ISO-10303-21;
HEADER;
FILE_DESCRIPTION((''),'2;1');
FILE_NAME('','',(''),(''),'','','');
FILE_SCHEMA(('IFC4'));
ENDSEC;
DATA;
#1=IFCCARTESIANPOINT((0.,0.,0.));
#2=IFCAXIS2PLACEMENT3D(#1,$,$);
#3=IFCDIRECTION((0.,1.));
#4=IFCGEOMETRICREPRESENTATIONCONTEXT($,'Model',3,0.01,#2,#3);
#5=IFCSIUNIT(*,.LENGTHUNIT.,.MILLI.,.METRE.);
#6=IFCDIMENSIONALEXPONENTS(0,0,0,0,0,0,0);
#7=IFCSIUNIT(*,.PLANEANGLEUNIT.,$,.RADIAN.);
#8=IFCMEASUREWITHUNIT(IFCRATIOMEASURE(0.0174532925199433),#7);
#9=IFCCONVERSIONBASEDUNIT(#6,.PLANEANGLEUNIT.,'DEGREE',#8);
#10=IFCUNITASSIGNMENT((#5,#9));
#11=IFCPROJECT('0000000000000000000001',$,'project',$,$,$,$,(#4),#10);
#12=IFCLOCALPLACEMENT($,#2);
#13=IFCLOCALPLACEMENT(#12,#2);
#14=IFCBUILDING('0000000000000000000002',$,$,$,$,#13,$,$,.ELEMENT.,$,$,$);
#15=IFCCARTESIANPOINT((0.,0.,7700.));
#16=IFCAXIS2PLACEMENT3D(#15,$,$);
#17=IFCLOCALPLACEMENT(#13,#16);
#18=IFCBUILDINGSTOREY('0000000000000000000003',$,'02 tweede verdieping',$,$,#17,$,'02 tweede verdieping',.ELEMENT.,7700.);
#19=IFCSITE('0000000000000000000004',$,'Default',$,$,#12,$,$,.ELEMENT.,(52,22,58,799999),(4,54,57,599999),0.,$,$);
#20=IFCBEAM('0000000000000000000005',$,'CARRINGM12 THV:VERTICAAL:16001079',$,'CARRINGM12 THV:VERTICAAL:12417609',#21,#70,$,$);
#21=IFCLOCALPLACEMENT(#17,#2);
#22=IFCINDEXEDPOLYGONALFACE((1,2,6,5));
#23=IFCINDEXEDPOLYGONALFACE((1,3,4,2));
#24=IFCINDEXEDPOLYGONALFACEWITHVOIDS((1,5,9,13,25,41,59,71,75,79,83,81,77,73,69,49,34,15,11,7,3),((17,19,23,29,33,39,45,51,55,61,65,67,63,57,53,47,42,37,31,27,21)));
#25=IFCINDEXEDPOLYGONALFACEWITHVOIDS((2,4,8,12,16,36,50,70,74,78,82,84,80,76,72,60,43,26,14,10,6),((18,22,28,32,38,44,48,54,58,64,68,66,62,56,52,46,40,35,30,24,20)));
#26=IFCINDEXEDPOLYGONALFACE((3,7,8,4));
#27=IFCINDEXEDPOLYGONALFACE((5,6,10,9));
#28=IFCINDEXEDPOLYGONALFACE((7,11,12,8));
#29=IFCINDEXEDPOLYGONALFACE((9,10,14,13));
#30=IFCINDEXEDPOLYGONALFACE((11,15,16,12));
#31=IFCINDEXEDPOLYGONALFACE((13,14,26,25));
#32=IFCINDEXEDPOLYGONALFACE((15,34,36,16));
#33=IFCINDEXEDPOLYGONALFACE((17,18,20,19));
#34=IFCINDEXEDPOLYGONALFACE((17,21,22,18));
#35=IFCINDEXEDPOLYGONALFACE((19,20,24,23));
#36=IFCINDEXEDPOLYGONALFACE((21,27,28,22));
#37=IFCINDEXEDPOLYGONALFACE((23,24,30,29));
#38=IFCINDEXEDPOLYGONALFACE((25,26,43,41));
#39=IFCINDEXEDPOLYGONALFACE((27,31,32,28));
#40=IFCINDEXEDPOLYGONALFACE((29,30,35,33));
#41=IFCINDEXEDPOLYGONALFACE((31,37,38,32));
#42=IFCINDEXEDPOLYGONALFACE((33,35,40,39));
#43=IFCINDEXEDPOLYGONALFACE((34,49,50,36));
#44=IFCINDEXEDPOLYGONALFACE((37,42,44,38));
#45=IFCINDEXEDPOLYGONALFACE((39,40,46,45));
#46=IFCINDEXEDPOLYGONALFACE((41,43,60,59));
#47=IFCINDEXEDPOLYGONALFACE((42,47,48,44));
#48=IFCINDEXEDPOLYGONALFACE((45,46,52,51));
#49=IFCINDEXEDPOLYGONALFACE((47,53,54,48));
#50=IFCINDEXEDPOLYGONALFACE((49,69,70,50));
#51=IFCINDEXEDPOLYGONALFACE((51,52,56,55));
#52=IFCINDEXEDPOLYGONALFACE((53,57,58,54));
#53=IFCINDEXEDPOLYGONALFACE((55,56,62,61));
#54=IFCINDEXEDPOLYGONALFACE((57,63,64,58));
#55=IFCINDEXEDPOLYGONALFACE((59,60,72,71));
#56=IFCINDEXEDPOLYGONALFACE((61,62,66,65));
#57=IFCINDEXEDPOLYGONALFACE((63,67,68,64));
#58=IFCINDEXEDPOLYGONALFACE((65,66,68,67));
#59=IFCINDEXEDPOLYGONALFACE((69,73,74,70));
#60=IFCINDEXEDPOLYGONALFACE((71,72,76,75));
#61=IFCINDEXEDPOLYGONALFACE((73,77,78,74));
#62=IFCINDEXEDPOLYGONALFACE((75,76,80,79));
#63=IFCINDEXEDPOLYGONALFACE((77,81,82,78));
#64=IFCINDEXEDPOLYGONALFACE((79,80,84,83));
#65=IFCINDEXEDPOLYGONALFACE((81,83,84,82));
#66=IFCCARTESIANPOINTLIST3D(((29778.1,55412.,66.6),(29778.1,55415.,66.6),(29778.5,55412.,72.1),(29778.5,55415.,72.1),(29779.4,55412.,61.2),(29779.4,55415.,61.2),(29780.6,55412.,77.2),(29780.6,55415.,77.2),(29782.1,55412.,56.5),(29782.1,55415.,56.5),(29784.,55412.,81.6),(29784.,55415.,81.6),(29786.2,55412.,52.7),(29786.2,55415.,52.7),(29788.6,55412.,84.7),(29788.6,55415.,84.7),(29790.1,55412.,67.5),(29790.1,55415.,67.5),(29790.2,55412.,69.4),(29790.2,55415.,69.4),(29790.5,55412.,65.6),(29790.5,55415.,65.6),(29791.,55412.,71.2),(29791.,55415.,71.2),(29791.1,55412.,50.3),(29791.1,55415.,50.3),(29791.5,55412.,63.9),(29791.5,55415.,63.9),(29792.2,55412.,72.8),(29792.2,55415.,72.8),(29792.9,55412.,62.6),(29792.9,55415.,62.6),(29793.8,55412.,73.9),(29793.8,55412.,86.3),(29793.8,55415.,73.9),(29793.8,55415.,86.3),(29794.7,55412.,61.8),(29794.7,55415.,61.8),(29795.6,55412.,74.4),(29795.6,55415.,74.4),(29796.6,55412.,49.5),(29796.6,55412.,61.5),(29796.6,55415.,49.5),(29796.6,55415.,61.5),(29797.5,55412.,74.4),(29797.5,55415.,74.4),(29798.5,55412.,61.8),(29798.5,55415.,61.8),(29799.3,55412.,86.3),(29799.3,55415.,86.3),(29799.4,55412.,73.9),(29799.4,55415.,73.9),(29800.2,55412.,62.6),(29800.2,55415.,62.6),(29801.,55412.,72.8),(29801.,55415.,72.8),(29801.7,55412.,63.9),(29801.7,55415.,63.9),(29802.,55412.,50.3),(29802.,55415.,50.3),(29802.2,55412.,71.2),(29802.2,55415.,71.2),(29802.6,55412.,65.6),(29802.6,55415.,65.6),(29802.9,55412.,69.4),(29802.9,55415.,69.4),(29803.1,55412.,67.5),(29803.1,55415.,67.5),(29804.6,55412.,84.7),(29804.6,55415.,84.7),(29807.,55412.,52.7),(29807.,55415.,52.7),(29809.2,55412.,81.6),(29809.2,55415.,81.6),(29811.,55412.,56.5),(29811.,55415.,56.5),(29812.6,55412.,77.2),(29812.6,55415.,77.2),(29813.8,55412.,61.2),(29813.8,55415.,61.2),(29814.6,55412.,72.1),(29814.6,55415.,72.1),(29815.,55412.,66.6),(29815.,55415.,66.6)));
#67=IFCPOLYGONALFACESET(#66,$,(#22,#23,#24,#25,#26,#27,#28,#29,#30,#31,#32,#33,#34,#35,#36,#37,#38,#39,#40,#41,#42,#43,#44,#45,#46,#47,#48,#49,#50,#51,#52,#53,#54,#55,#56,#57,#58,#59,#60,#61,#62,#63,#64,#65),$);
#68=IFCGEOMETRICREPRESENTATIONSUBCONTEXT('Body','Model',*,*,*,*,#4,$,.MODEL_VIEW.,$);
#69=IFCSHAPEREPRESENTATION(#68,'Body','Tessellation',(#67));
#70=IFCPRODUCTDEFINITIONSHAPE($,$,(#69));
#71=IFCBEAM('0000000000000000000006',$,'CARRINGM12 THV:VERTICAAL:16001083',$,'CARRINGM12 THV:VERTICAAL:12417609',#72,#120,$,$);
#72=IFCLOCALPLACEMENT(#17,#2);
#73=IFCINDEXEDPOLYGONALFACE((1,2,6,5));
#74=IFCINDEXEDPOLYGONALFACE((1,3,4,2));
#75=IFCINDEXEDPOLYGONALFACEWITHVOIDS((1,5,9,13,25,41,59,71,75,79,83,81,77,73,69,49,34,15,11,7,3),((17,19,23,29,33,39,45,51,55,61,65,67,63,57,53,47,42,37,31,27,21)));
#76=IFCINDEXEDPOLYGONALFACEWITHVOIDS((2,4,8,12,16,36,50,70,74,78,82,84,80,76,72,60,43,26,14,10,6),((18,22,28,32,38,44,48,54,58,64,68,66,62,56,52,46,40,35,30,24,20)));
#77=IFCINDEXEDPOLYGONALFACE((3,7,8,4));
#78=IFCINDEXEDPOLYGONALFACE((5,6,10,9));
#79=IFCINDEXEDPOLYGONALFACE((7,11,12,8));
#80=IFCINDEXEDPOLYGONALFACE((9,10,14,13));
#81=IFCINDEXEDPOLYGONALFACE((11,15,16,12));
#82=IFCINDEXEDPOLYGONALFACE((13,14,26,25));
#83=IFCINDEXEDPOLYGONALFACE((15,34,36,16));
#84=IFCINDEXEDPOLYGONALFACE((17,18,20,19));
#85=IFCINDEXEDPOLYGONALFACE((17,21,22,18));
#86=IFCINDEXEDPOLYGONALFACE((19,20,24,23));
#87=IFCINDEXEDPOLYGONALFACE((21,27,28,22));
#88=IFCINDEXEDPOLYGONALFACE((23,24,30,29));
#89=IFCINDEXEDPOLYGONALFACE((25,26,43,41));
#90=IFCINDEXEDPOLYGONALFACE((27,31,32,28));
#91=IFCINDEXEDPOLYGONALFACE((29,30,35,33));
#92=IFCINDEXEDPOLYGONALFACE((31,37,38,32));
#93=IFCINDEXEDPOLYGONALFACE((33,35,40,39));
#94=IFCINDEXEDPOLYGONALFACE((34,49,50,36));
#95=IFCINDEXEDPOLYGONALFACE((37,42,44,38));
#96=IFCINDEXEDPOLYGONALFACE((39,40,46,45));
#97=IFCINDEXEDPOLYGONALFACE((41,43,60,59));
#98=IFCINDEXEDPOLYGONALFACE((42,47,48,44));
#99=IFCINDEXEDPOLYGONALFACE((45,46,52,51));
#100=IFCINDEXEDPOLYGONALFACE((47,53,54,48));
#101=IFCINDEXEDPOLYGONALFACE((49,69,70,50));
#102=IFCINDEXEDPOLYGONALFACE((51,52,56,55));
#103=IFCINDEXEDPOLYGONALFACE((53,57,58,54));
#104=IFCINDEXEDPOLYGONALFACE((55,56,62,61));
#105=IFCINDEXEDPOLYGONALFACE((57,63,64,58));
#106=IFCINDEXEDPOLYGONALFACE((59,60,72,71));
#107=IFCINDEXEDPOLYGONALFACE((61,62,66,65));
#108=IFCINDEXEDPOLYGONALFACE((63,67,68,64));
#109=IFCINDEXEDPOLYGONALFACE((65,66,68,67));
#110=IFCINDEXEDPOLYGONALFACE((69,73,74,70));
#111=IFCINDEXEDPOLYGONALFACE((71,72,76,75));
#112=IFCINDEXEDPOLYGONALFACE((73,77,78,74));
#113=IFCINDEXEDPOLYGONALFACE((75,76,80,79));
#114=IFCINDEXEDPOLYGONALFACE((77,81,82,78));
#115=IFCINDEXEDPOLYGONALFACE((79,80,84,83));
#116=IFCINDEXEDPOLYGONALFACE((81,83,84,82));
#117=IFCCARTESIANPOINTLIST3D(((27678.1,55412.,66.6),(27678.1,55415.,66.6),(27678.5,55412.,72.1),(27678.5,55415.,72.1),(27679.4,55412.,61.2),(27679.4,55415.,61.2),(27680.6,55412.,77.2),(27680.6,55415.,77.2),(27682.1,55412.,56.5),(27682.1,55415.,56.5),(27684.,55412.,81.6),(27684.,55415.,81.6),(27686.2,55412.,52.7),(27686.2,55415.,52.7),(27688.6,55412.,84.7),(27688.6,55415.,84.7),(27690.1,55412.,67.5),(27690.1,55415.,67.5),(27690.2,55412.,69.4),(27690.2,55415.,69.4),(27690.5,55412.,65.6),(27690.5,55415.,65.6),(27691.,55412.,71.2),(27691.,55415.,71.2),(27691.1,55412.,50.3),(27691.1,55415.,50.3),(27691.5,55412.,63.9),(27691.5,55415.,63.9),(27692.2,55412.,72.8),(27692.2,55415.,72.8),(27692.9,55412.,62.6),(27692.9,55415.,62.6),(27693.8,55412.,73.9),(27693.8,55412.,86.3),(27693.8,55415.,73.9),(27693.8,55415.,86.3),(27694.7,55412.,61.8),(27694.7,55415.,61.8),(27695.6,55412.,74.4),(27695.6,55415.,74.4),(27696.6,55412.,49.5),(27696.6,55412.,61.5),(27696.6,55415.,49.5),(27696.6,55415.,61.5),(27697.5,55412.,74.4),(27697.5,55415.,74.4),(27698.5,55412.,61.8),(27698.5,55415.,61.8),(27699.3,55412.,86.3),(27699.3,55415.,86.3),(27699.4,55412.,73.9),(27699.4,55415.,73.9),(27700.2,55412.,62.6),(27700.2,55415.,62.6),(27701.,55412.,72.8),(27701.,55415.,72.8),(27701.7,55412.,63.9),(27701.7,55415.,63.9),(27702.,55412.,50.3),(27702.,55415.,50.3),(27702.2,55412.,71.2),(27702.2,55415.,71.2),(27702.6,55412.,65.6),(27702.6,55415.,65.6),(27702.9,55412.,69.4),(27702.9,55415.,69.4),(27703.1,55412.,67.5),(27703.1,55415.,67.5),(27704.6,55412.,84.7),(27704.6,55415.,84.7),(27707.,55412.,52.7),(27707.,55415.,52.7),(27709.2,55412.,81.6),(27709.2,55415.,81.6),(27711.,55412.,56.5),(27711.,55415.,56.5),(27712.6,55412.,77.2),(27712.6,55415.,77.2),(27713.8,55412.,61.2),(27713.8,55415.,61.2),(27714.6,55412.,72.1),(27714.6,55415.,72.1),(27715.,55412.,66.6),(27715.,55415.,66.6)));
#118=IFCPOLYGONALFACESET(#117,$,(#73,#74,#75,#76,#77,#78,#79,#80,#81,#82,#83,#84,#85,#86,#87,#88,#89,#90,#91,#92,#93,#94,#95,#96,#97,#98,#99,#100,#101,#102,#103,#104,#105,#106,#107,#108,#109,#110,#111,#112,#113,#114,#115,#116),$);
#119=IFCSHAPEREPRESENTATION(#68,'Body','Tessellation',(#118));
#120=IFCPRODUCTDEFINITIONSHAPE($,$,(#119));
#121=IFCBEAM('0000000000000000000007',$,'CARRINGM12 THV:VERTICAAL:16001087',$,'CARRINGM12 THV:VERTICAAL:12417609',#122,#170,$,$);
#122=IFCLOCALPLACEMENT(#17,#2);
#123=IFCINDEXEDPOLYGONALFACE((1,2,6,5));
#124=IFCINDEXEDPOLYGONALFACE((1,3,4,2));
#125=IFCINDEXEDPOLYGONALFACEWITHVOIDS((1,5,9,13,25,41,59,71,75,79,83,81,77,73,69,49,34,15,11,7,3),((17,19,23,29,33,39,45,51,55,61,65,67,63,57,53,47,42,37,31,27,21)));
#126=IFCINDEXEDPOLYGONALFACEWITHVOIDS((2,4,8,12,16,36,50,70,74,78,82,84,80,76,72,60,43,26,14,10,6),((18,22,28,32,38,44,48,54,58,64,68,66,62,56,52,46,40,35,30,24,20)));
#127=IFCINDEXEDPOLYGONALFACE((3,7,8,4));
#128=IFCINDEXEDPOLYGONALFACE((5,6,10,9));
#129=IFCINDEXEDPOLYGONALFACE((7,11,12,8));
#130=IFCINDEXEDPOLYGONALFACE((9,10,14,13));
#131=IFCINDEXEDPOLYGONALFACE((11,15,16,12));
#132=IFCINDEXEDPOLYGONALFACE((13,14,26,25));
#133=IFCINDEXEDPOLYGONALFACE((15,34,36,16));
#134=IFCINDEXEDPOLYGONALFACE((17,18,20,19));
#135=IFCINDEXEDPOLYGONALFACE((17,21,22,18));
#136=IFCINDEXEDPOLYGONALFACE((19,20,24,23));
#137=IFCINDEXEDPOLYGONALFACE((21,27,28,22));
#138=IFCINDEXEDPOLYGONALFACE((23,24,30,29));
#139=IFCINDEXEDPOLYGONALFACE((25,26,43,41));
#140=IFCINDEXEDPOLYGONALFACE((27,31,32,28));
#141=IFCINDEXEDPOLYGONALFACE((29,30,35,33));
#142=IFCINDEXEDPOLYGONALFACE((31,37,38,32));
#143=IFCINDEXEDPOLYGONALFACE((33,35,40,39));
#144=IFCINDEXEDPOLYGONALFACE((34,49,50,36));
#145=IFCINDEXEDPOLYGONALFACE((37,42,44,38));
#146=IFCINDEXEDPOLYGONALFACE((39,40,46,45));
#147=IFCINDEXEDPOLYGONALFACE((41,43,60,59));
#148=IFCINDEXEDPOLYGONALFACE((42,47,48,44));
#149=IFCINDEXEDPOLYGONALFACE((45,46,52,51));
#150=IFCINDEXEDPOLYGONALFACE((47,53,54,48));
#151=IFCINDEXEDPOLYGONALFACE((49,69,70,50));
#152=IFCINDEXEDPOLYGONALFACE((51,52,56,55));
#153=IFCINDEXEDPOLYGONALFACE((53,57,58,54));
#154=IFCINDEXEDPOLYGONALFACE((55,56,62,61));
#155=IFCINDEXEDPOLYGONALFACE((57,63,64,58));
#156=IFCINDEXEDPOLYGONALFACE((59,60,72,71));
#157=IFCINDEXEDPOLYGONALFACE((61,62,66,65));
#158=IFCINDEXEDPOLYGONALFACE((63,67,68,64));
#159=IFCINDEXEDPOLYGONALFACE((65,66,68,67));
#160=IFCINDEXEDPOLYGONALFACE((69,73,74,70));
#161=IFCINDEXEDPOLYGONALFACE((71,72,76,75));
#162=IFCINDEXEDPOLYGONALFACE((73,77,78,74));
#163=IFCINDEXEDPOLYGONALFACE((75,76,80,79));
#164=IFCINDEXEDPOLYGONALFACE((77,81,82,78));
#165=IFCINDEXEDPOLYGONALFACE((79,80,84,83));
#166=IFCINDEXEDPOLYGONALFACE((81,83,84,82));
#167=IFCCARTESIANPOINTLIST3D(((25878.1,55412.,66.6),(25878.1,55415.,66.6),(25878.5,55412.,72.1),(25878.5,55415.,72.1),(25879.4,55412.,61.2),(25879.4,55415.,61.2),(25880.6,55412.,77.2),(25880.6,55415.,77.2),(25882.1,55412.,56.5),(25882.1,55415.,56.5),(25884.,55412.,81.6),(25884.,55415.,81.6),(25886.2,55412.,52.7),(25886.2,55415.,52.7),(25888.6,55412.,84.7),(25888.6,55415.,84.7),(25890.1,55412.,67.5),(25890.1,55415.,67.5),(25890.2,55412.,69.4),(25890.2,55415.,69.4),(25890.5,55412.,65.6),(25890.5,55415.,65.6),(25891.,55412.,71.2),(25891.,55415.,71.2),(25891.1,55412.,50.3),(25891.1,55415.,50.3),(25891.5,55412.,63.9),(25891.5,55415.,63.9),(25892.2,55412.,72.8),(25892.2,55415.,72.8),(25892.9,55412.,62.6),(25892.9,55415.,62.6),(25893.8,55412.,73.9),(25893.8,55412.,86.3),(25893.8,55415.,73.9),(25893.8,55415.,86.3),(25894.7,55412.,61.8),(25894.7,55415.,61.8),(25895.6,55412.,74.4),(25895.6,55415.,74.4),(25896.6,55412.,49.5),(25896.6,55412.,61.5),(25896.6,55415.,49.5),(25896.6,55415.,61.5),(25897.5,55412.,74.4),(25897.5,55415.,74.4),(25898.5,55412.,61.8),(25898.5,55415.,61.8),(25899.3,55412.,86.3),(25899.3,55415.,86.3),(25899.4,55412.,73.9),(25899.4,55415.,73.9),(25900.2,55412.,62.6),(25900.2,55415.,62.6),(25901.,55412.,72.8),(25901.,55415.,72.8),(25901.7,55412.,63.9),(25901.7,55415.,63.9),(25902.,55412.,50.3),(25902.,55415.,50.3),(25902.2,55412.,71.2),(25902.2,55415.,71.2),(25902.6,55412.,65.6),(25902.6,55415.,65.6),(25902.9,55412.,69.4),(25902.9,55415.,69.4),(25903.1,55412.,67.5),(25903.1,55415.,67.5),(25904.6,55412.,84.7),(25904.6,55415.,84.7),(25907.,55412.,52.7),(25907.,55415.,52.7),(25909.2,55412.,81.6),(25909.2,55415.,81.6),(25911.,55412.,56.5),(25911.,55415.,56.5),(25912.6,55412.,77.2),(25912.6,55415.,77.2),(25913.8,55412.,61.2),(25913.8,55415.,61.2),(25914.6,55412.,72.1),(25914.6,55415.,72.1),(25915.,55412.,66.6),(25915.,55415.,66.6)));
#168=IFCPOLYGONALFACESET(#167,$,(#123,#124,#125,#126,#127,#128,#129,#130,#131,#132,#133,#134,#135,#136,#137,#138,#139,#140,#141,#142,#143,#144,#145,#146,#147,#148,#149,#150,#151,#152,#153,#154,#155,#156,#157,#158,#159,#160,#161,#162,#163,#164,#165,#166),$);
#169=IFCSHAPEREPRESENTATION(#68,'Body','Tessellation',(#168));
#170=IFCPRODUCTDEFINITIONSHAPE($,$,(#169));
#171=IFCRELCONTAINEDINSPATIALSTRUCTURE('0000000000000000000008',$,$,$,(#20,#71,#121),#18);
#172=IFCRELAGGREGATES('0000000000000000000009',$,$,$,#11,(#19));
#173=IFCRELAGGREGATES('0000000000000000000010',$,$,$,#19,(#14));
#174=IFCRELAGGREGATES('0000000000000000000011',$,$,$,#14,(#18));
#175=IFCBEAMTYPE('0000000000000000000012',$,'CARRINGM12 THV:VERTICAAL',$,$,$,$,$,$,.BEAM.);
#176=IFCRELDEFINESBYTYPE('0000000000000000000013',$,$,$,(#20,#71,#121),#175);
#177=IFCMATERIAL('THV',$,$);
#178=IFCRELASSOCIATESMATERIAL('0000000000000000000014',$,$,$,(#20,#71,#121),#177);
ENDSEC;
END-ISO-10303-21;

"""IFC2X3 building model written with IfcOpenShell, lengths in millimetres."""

from ifc_helpers import new_model, entity, si_unit, converted_unit, direction, frame, origin, origin_2d_with_axis, place, context, subcontext, project, spatial, hollow_circle, extrude, material, type_object, element, save


model = new_model("IFC2X3")

# Units and contexts
model_context = context("Model", 3, precision=0.01, world=origin(), true_north=direction((0.0, 1.0)))
body_context = subcontext(model_context, "Body", "Model", "MODEL_VIEW")
ifc_project = project(units=[si_unit("LENGTHUNIT", "METRE", prefix="MILLI"), converted_unit("PLANEANGLEUNIT", "DEGREE", entity("IfcRatioMeasure", 0.0174532925199433), si_unit("PLANEANGLEUNIT", "RADIAN"), dimensions=[0, 0, 0, 0, 0, 0, 0])], contexts=[model_context])

# Site, building, storey
site_placement = place(None, origin())
site = spatial("IfcSite", under=ifc_project, at=site_placement, Name="Default", CompositionType="ELEMENT", RefLatitude=(52, 22, 58, 799999), RefLongitude=(4, 54, 57, 599999), RefElevation=0.0)
building_placement = place(site_placement, origin())
building = spatial("IfcBuilding", under=site, at=building_placement, CompositionType="ELEMENT")
storey_placement = place(building_placement, frame((0.0, 0.0, 7700.0)))
storey = spatial("IfcBuildingStorey", under=building, at=storey_placement, Name="02 tweede verdieping", LongName="02 tweede verdieping", CompositionType="ELEMENT", Elevation=7700.0)

# Beams
ifc_material_1 = material(Name="THV")
beam_type_1 = type_object("IfcBeamType", Name="CARRINGM12 THV:VERTICAAL", PredefinedType="BEAM")
beam_1_placement = place(storey_placement, origin())
element("IfcBeam", 1, at=beam_1_placement, inside=storey, type_object=beam_type_1, material=ifc_material_1, Name="CARRINGM12 THV:VERTICAAL:16001079", ObjectType="CARRINGM12 THV:VERTICAAL:12417609", context=body_context, shape_type="SweptSolid", body=[
    extrude(hollow_circle(Radius=18.5, WallThickness=12.0, at=origin_2d_with_axis()), frame((29796.6, 55412.0, 68.0), z_axis=(0.0, 1.0, 0.0), x_axis=(0.0, 0.0, -1.0)), (0.0, 0.0, 1.0), 3.0),
])
beam_2_placement = place(storey_placement, origin())
element("IfcBeam", 2, at=beam_2_placement, inside=storey, type_object=beam_type_1, material=ifc_material_1, Name="CARRINGM12 THV:VERTICAAL:16001083", ObjectType="CARRINGM12 THV:VERTICAAL:12417609", context=body_context, shape_type="SweptSolid", body=[
    extrude(hollow_circle(Radius=18.5, WallThickness=12.0, at=origin_2d_with_axis()), frame((27696.6, 55412.0, 68.0), z_axis=(0.0, 1.0, 0.0), x_axis=(0.0, 0.0, -1.0)), (0.0, 0.0, 1.0), 3.0),
])
beam_3_placement = place(storey_placement, origin())
element("IfcBeam", 3, at=beam_3_placement, inside=storey, type_object=beam_type_1, material=ifc_material_1, Name="CARRINGM12 THV:VERTICAAL:16001087", ObjectType="CARRINGM12 THV:VERTICAAL:12417609", context=body_context, shape_type="SweptSolid", body=[
    extrude(hollow_circle(Radius=18.5, WallThickness=12.0, at=origin_2d_with_axis()), frame((25896.6, 55412.0, 68.0), z_axis=(0.0, 1.0, 0.0), x_axis=(0.0, 0.0, -1.0)), (0.0, 0.0, 1.0), 3.0),
])

save(model, "model.ifc")
